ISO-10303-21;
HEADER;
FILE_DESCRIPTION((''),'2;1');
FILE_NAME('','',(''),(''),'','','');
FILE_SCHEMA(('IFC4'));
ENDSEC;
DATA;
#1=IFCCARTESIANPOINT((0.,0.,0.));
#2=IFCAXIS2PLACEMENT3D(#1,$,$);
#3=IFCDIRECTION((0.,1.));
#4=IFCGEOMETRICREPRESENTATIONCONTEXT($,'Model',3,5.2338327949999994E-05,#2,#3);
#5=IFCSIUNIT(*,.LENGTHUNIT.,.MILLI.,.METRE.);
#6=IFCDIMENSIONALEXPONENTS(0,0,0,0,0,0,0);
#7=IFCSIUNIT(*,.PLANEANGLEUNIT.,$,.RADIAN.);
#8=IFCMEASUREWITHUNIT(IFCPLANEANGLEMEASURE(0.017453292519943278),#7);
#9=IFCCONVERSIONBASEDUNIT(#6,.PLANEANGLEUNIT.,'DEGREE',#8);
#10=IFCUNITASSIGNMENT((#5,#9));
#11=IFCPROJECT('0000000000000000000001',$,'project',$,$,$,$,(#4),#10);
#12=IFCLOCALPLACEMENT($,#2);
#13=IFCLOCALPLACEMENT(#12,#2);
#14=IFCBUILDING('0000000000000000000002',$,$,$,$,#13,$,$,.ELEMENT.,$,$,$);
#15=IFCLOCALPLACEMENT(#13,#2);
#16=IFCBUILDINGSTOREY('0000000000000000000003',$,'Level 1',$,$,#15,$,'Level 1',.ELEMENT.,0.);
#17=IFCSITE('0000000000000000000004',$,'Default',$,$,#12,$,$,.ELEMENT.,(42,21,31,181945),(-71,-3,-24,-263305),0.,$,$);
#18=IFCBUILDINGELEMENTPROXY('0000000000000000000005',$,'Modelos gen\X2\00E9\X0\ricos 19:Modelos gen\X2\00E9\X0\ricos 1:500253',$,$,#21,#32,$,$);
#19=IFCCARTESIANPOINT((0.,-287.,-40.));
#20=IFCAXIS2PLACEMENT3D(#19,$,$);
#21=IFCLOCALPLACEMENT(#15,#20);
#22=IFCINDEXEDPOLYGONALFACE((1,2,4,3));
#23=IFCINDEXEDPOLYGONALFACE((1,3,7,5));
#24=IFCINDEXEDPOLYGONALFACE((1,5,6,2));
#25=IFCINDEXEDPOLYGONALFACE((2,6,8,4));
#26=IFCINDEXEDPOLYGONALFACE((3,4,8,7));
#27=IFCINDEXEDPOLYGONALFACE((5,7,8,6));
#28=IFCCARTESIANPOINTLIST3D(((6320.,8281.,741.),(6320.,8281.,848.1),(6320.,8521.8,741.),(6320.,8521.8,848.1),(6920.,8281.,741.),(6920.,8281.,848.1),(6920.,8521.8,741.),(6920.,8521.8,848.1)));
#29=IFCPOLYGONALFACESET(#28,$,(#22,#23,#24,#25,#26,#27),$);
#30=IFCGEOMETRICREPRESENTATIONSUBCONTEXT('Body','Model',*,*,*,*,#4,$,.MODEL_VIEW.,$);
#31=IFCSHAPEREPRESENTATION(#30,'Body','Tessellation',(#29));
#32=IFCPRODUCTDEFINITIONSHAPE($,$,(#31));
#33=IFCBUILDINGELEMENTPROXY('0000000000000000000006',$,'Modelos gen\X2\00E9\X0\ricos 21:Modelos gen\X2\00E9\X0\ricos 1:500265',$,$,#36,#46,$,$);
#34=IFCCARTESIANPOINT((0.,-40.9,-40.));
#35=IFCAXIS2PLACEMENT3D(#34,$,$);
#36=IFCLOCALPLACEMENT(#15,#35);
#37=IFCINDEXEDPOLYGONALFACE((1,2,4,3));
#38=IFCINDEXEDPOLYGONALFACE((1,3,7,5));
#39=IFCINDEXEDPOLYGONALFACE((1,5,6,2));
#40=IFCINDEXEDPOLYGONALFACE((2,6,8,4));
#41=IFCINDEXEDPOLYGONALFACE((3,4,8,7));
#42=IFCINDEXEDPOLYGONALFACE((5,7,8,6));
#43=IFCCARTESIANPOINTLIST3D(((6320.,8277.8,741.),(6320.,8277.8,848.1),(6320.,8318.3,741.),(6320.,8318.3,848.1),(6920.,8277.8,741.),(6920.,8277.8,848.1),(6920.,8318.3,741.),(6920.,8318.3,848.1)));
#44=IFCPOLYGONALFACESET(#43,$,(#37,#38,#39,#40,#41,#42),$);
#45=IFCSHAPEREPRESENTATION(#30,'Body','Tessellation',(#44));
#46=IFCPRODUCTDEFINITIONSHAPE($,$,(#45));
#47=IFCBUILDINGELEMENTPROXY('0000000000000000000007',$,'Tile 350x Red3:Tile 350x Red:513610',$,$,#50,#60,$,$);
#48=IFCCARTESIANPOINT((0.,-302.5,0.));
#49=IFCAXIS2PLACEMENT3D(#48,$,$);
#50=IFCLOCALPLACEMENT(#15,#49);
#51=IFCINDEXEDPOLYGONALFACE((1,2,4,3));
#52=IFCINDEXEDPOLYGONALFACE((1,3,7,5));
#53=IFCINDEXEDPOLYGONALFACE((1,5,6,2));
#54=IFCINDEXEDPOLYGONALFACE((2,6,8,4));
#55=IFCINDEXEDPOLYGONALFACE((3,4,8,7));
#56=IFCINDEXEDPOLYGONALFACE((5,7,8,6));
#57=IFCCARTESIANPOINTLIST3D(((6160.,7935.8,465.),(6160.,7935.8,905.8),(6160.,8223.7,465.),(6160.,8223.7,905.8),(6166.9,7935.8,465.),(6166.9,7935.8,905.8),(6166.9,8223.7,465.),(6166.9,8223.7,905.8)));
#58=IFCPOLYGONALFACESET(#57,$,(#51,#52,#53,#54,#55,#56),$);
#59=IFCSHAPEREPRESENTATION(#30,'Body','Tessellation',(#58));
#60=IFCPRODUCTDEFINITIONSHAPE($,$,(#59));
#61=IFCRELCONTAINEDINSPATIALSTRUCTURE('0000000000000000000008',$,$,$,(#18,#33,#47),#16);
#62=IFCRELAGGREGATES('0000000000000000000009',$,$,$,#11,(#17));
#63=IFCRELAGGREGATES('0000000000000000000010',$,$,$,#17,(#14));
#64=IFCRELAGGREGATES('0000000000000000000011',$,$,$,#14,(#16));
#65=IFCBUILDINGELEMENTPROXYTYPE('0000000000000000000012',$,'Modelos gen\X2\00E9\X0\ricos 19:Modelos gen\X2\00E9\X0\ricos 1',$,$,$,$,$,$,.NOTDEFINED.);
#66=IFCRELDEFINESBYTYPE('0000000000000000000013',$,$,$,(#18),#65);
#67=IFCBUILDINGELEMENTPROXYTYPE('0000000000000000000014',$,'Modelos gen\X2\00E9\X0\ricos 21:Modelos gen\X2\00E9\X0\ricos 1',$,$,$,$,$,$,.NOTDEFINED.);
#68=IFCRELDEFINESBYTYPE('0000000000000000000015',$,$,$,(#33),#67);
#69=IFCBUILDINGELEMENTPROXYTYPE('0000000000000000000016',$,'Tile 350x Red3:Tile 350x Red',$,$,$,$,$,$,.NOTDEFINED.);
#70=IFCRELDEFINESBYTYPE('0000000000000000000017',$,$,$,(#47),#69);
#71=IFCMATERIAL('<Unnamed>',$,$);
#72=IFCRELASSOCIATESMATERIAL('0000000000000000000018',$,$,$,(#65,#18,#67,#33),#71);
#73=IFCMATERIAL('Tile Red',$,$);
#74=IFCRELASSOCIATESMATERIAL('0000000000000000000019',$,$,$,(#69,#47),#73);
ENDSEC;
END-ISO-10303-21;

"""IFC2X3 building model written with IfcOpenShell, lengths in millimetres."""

from ifc_helpers import new_model, entity, si_unit, converted_unit, direction, frame, frame_2d, origin, origin_2d_with_axis, place, context, subcontext, project, spatial, rectangle, extrude, source, transform, mapped, material, type_object, type_shapes, element, save


model = new_model("IFC2X3")

# Units and contexts
model_context = context("Model", 3, precision=5.2338327949999994e-05, world=origin(), true_north=direction((0.0, 1.0)))
body_context = subcontext(model_context, "Body", "Model", "MODEL_VIEW")
ifc_project = project(units=[si_unit("LENGTHUNIT", "METRE", prefix="MILLI"), converted_unit("PLANEANGLEUNIT", "DEGREE", entity("IfcPlaneAngleMeasure", 0.017453292519943278), si_unit("PLANEANGLEUNIT", "RADIAN"), dimensions=[0, 0, 0, 0, 0, 0, 0])], contexts=[model_context])

# Site, building, storey
site_placement = place(None, origin())
site = spatial("IfcSite", under=ifc_project, at=site_placement, Name="Default", CompositionType="ELEMENT", RefLatitude=(42, 21, 31, 181945), RefLongitude=(-71, -3, -24, -263305), RefElevation=0.0)
building_placement = place(site_placement, origin())
building = spatial("IfcBuilding", under=site, at=building_placement, CompositionType="ELEMENT")
storey_placement = place(building_placement, origin())
storey = spatial("IfcBuildingStorey", under=building, at=storey_placement, Name="Level 1", LongName="Level 1", CompositionType="ELEMENT", Elevation=0.0)

# Building element proxies
ifc_material_1 = material(Name="Tile Red")
ifc_material_2 = material(Name="<Unnamed>")
building_element_proxy_type_1 = type_object("IfcBuildingElementProxyType", Name="Modelos genéricos 19:Modelos genéricos 1", PredefinedType="NOTDEFINED", material=ifc_material_2)
shared_shape_1 = source(origin(), body_context, "Body", "SweptSolid", [
    extrude(rectangle(XDim=600.0, YDim=240.9, at=origin_2d_with_axis()), frame((6620.0, 8401.4, 741.0), z_axis=(0.0, 0.0, 1.0), x_axis=(-1.0, 0.0, 0.0)), (0.0, 0.0, 1.0), 107.1),
])
type_shapes(building_element_proxy_type_1, [shared_shape_1])
proxy_1_placement = place(storey_placement, frame((0.0, -287.0, -40.0)))
element("IfcBuildingElementProxy", 1, at=proxy_1_placement, inside=storey, type_object=building_element_proxy_type_1, material=ifc_material_2, Name="Modelos genéricos 19:Modelos genéricos 1:500253", context=body_context, shape_type="MappedRepresentation", body=[
    mapped(shared_shape_1, transform((0.0, 0.0, 0.0), scale=1.0)),
])
building_element_proxy_type_2 = type_object("IfcBuildingElementProxyType", Name="Modelos genéricos 21:Modelos genéricos 1", PredefinedType="NOTDEFINED", material=ifc_material_2)
shared_shape_2 = source(origin(), body_context, "Body", "SweptSolid", [
    extrude(rectangle(XDim=600.0, YDim=40.4, at=origin_2d_with_axis()), frame((6620.0, 8298.1, 741.0), z_axis=(0.0, 0.0, 1.0), x_axis=(-1.0, 0.0, 0.0)), (0.0, 0.0, 1.0), 107.1),
])
type_shapes(building_element_proxy_type_2, [shared_shape_2])
proxy_2_placement = place(storey_placement, frame((0.0, -40.9, -40.0)))
element("IfcBuildingElementProxy", 2, at=proxy_2_placement, inside=storey, type_object=building_element_proxy_type_2, material=ifc_material_2, Name="Modelos genéricos 21:Modelos genéricos 1:500265", context=body_context, shape_type="MappedRepresentation", body=[
    mapped(shared_shape_2, transform((0.0, 0.0, 0.0), scale=1.0)),
])
building_element_proxy_type_3 = type_object("IfcBuildingElementProxyType", Name="Tile 350x Red3:Tile 350x Red", PredefinedType="NOTDEFINED", material=ifc_material_1)
shared_shape_3 = source(origin(), body_context, "Body", "SweptSolid", [
    extrude(rectangle(XDim=6.9, YDim=287.9, at=frame_2d((0.0, 0.0), x_axis=(1.0, 0.0))), frame((6163.4, 8079.7, 465.0), z_axis=(0.0, 0.0, 1.0), x_axis=(-1.0, 0.0, 0.0)), (0.0, 0.0, 1.0), 440.8),
])
type_shapes(building_element_proxy_type_3, [shared_shape_3])
proxy_3_placement = place(storey_placement, frame((0.0, -302.5, 0.0)))
element("IfcBuildingElementProxy", 3, at=proxy_3_placement, inside=storey, type_object=building_element_proxy_type_3, material=ifc_material_1, Name="Tile 350x Red3:Tile 350x Red:513610", context=body_context, shape_type="MappedRepresentation", body=[
    mapped(shared_shape_3, transform((0.0, 0.0, 0.0), scale=1.0)),
])

save(model, "model.ifc")
